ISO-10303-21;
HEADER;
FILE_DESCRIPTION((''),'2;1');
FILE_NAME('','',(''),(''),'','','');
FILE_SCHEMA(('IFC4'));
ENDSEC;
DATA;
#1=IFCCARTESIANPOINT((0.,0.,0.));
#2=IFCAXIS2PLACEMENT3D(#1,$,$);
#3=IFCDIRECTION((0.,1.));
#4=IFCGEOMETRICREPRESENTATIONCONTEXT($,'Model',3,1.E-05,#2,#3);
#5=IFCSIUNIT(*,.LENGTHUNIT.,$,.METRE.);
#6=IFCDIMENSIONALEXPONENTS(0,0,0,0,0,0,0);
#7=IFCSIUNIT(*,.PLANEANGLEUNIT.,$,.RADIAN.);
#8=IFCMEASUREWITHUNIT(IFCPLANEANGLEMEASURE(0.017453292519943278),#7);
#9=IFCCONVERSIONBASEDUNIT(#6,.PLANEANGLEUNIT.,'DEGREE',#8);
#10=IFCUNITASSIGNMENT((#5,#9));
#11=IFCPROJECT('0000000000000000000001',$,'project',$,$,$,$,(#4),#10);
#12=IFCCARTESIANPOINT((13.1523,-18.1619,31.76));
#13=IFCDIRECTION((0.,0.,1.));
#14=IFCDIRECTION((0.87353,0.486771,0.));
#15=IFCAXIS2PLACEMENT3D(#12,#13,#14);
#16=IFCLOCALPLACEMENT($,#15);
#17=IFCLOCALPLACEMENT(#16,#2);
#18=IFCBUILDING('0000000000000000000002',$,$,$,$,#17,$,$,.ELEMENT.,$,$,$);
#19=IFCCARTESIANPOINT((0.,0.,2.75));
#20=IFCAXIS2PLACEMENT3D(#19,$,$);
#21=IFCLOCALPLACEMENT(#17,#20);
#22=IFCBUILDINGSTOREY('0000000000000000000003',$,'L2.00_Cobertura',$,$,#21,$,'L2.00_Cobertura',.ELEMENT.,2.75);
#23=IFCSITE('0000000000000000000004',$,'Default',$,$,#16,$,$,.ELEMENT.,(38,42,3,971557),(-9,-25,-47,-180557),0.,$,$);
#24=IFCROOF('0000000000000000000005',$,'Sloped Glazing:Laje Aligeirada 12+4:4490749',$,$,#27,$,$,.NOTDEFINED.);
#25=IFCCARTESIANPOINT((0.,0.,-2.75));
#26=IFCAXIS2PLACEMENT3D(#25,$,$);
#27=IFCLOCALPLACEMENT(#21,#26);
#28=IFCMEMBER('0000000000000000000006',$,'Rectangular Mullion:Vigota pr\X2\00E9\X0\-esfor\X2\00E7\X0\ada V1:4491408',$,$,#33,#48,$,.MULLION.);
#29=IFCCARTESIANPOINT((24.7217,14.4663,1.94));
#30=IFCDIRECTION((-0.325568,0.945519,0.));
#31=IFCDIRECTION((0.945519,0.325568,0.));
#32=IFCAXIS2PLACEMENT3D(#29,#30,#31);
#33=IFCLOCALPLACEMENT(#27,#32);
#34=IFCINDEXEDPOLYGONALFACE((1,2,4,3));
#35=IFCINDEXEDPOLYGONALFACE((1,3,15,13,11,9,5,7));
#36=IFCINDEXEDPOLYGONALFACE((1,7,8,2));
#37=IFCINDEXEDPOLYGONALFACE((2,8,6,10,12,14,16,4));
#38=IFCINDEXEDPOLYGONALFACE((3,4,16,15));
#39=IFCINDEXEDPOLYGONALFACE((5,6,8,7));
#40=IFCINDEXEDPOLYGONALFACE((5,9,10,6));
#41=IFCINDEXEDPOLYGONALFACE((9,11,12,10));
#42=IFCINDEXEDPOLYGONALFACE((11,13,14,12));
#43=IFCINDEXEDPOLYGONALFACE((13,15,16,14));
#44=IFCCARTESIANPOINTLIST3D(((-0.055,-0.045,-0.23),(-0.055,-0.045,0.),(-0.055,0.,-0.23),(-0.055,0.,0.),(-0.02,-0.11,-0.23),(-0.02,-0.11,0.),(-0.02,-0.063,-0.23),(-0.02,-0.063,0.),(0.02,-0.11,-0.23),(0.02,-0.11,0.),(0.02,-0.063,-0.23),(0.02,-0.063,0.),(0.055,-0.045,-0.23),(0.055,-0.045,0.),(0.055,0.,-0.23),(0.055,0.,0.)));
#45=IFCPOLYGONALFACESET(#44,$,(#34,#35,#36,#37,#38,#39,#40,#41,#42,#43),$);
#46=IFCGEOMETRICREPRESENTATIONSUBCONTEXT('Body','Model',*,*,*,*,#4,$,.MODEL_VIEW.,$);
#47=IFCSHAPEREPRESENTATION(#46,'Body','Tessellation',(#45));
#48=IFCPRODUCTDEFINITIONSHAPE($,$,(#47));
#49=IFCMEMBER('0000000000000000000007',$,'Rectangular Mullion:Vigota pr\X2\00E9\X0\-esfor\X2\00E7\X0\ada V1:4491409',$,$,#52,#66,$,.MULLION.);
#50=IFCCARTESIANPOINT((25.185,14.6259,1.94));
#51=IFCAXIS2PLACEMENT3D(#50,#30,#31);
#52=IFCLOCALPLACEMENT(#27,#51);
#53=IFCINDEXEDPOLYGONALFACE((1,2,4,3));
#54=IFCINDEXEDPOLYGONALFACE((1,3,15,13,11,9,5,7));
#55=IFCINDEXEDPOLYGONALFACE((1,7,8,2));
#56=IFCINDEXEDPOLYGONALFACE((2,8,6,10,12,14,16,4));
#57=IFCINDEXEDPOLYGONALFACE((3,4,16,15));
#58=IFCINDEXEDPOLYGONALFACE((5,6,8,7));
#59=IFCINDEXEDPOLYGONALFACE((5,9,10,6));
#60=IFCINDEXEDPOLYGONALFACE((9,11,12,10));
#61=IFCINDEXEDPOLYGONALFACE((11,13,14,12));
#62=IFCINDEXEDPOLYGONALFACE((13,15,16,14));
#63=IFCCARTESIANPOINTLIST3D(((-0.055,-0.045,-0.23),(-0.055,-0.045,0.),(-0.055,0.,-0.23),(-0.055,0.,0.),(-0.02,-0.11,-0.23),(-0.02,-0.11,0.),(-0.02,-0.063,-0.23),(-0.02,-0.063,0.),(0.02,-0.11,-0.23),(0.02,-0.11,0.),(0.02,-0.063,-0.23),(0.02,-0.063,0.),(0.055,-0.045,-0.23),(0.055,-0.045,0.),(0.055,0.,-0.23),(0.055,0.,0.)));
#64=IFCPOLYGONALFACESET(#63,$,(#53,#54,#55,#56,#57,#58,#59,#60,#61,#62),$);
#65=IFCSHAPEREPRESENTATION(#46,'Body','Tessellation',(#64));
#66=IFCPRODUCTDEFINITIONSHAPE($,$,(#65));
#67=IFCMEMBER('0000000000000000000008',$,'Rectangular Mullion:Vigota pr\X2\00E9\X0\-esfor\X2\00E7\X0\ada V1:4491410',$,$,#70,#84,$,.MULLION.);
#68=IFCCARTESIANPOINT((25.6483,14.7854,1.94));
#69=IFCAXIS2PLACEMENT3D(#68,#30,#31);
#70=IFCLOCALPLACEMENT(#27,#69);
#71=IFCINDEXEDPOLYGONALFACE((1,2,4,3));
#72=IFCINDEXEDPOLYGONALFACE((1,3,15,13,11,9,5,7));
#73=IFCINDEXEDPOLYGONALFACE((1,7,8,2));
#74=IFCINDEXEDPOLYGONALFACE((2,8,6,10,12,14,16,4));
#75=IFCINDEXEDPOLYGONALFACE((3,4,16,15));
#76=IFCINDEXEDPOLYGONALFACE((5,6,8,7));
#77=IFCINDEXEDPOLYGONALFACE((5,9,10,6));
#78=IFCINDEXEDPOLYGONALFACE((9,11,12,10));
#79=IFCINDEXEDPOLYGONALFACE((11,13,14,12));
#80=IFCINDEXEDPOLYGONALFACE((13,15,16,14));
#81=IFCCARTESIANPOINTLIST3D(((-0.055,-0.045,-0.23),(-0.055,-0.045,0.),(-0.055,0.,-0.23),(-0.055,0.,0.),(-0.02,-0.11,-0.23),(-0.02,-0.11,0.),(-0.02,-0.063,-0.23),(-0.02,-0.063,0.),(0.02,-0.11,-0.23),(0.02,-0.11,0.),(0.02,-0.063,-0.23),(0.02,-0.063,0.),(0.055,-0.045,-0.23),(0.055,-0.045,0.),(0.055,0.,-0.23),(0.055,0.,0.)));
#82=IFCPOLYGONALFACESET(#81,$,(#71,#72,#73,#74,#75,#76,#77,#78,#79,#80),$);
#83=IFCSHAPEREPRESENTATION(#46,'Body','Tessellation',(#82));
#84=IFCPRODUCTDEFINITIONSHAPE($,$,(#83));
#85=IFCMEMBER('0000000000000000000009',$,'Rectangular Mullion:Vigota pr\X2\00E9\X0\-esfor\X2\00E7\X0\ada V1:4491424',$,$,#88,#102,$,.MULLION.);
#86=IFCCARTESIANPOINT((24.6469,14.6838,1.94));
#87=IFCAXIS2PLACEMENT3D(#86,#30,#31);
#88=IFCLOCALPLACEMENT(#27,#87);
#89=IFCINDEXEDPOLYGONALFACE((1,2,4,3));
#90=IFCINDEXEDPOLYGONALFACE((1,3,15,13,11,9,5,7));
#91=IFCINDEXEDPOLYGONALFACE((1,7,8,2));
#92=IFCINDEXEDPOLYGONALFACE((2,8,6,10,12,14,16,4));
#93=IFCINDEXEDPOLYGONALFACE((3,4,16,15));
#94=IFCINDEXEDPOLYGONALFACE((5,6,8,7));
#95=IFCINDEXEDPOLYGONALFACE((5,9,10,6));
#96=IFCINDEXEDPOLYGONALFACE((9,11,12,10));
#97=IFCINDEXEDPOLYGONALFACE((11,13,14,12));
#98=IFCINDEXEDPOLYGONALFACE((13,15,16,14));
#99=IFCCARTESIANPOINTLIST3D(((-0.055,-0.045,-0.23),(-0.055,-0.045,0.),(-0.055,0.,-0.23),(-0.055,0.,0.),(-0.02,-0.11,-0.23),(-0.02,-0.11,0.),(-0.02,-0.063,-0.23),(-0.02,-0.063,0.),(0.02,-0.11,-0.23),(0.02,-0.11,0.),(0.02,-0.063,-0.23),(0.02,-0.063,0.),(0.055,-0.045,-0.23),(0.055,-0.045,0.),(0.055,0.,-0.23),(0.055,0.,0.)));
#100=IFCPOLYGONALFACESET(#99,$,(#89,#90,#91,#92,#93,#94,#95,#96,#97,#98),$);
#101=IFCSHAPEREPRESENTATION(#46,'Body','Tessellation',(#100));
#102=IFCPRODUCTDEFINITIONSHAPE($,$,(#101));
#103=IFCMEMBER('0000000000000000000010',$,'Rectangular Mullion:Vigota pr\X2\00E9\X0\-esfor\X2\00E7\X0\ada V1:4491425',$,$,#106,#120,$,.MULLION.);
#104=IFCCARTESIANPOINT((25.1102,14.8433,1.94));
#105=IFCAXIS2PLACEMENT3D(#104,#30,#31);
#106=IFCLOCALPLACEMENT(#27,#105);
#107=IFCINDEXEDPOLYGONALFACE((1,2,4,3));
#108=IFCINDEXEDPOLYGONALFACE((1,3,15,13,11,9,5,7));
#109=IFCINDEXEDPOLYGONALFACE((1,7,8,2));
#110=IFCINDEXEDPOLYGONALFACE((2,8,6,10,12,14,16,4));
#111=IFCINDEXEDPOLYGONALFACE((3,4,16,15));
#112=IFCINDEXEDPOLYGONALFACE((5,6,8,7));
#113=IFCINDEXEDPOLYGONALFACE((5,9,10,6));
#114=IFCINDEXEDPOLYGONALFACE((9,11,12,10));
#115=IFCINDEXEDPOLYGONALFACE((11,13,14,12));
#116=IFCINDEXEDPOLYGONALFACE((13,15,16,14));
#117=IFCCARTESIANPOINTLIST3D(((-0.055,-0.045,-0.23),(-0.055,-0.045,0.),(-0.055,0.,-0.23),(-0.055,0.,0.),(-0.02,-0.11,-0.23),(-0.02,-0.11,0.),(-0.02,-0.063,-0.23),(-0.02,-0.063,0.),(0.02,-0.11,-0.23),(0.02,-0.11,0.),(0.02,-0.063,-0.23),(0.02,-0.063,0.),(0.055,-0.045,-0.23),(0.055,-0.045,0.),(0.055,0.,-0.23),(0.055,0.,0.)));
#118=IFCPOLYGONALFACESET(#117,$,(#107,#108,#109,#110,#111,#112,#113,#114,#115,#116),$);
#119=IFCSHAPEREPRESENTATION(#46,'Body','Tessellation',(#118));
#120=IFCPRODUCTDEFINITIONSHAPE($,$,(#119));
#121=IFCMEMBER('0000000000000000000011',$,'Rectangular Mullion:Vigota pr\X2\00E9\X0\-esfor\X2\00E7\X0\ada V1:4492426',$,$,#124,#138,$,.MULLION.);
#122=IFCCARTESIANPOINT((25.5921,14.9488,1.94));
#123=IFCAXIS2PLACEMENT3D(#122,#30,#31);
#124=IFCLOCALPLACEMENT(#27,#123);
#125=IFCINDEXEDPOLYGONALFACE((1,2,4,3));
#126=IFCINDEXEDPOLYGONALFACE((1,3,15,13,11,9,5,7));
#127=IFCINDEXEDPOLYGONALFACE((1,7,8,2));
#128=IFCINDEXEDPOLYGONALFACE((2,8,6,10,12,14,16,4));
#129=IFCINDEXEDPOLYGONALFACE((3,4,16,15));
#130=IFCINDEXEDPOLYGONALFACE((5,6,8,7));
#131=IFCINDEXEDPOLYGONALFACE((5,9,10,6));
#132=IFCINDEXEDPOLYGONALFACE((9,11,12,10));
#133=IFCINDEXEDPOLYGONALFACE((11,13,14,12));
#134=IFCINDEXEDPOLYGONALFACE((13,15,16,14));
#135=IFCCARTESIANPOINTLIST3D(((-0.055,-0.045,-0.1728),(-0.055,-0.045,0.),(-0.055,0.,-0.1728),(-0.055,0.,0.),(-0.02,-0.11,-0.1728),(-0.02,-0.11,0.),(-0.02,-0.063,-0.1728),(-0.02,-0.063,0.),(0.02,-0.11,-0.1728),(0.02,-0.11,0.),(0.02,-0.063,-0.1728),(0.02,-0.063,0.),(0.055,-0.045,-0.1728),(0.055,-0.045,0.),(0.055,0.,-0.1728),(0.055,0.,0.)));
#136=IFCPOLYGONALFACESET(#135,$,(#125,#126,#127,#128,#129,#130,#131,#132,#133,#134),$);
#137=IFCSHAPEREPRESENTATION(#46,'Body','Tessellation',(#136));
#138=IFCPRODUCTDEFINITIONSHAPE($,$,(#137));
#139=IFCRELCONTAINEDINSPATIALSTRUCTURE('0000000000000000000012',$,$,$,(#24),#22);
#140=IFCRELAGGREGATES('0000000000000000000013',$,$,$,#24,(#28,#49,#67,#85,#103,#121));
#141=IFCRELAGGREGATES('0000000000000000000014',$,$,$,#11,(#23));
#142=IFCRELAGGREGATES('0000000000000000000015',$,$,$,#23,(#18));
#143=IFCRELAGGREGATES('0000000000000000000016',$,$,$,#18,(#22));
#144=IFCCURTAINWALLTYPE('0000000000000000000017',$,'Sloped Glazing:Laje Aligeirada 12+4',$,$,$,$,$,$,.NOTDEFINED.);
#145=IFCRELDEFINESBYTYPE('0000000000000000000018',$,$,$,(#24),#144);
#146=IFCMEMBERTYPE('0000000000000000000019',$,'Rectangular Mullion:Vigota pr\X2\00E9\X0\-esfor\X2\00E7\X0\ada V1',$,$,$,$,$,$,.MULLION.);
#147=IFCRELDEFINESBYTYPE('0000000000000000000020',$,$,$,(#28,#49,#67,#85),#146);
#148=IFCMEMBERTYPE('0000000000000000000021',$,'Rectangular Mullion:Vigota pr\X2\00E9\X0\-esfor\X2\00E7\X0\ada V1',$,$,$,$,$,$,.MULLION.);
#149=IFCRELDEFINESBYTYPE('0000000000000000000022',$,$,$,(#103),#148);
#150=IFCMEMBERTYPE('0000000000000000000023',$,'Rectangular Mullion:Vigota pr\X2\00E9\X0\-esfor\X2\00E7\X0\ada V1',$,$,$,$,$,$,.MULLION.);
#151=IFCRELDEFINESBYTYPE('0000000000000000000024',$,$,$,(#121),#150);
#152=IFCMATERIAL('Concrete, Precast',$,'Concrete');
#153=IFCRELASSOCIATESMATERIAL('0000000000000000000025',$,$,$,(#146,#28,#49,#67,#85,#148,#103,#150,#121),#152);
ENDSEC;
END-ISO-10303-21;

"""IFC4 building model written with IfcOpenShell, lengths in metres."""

from ifc_helpers import new_model, entity, si_unit, converted_unit, direction, frame, origin, place, context, subcontext, project, spatial, indexed_curve, outline, extrude, source, transform, mapped, material, type_object, type_shapes, element, aggregate, save


model = new_model("IFC4")

# Units and contexts
model_context = context("Model", 3, precision=1e-05, world=origin(), true_north=direction((0.0, 1.0)))
body_context = subcontext(model_context, "Body", "Model", "MODEL_VIEW")
ifc_project = project(units=[si_unit("LENGTHUNIT", "METRE"), converted_unit("PLANEANGLEUNIT", "DEGREE", entity("IfcPlaneAngleMeasure", 0.017453292519943278), si_unit("PLANEANGLEUNIT", "RADIAN"), dimensions=[0, 0, 0, 0, 0, 0, 0])], contexts=[model_context])

# Site, building, storey
site_placement = place(None, frame((13.1523, -18.1619, 31.76), z_axis=(0.0, 0.0, 1.0), x_axis=(0.87353, 0.486771, 0.0)))
site = spatial("IfcSite", under=ifc_project, at=site_placement, Name="Default", CompositionType="ELEMENT", RefLatitude=(38, 42, 3, 971557), RefLongitude=(-9, -25, -47, -180557), RefElevation=0.0)
building_placement = place(site_placement, origin())
building = spatial("IfcBuilding", under=site, at=building_placement, CompositionType="ELEMENT")
storey_placement = place(building_placement, frame((0.0, 0.0, 2.75)))
storey = spatial("IfcBuildingStorey", under=building, at=storey_placement, Name="L2.00_Cobertura", LongName="L2.00_Cobertura", CompositionType="ELEMENT", Elevation=2.75)

# Roof, members
curtain_wall_type = type_object("IfcCurtainWallType", Name="Sloped Glazing:Laje Aligeirada 12+4", PredefinedType="NOTDEFINED")
roof_placement = place(storey_placement, frame((0.0, 0.0, -2.75)))
roof = element("IfcRoof", 1, at=roof_placement, inside=storey, type_object=curtain_wall_type, Name="Sloped Glazing:Laje Aligeirada 12+4:4490749", PredefinedType="NOTDEFINED")
ifc_material_1 = material(Name="Concrete, Precast", Category="Concrete")
member_type_1 = type_object("IfcMemberType", Name="Rectangular Mullion:Vigota pré-esforçada V1", PredefinedType="MULLION", material=ifc_material_1)
shared_shape_1 = source(origin(), body_context, "Body", "SweptSolid", [
    extrude(outline(indexed_curve([(-0.055, -0.0545), (0.055, -0.0545), (0.055, -0.0095), (0.02, 0.0085), (0.02, 0.0555), (-0.02, 0.0555), (-0.02, 0.0085), (-0.055, -0.0095), (-0.055, -0.0545)], self_intersect=False)), frame((0.0, -0.0545, -0.23), z_axis=(0.0, 0.0, 1.0), x_axis=(-1.0, 0.0, 0.0)), (0.0, 0.0, 1.0), 0.23),
])
type_shapes(member_type_1, [shared_shape_1])
member_1_placement = place(roof_placement, frame((24.7217, 14.4663, 1.94), z_axis=(-0.325568, 0.945519, 0.0), x_axis=(0.945519, 0.325568, 0.0)))
member_1 = element("IfcMember", 2, at=member_1_placement, type_object=member_type_1, material=ifc_material_1, Name="Rectangular Mullion:Vigota pré-esforçada V1:4491408", PredefinedType="MULLION", context=body_context, shape_type="MappedRepresentation", body=[
    mapped(shared_shape_1, transform((0.0, 0.0, 0.0), scale=1.0)),
])
member_2_placement = place(roof_placement, frame((25.185, 14.6259, 1.94), z_axis=(-0.325568, 0.945519, 0.0), x_axis=(0.945519, 0.325568, 0.0)))
member_2 = element("IfcMember", 3, at=member_2_placement, type_object=member_type_1, material=ifc_material_1, Name="Rectangular Mullion:Vigota pré-esforçada V1:4491409", PredefinedType="MULLION", context=body_context, shape_type="MappedRepresentation", body=[
    mapped(shared_shape_1, transform((0.0, 0.0, 0.0), scale=1.0)),
])
member_3_placement = place(roof_placement, frame((25.6483, 14.7854, 1.94), z_axis=(-0.325568, 0.945519, 0.0), x_axis=(0.945519, 0.325568, 0.0)))
member_3 = element("IfcMember", 4, at=member_3_placement, type_object=member_type_1, material=ifc_material_1, Name="Rectangular Mullion:Vigota pré-esforçada V1:4491410", PredefinedType="MULLION", context=body_context, shape_type="MappedRepresentation", body=[
    mapped(shared_shape_1, transform((0.0, 0.0, 0.0), scale=1.0)),
])
member_4_placement = place(roof_placement, frame((24.6469, 14.6838, 1.94), z_axis=(-0.325568, 0.945519, 0.0), x_axis=(0.945519, 0.325568, 0.0)))
member_4 = element("IfcMember", 5, at=member_4_placement, type_object=member_type_1, material=ifc_material_1, Name="Rectangular Mullion:Vigota pré-esforçada V1:4491424", PredefinedType="MULLION", context=body_context, shape_type="MappedRepresentation", body=[
    mapped(shared_shape_1, transform((0.0, 0.0, 0.0), scale=1.0)),
])
member_type_2 = type_object("IfcMemberType", Name="Rectangular Mullion:Vigota pré-esforçada V1", PredefinedType="MULLION", material=ifc_material_1)
shared_shape_2 = source(origin(), body_context, "Body", "SweptSolid", [
    extrude(outline(indexed_curve([(-0.055, -0.0545), (0.055, -0.0545), (0.055, -0.0095), (0.02, 0.0085), (0.02, 0.0555), (-0.02, 0.0555), (-0.02, 0.0085), (-0.055, -0.0095), (-0.055, -0.0545)], self_intersect=False)), frame((0.0, -0.0545, -0.23), z_axis=(0.0, 0.0, 1.0), x_axis=(-1.0, 0.0, 0.0)), (0.0, 0.0, 1.0), 0.23),
])
type_shapes(member_type_2, [shared_shape_2])
member_5_placement = place(roof_placement, frame((25.1102, 14.8433, 1.94), z_axis=(-0.325568, 0.945519, 0.0), x_axis=(0.945519, 0.325568, 0.0)))
member_5 = element("IfcMember", 6, at=member_5_placement, type_object=member_type_2, material=ifc_material_1, Name="Rectangular Mullion:Vigota pré-esforçada V1:4491425", PredefinedType="MULLION", context=body_context, shape_type="MappedRepresentation", body=[
    mapped(shared_shape_2, transform((0.0, 0.0, 0.0), scale=1.0)),
])
member_type_3 = type_object("IfcMemberType", Name="Rectangular Mullion:Vigota pré-esforçada V1", PredefinedType="MULLION", material=ifc_material_1)
shared_shape_3 = source(origin(), body_context, "Body", "SweptSolid", [
    extrude(outline(indexed_curve([(-0.055, -0.0545), (0.055, -0.0545), (0.055, -0.0095), (0.02, 0.0085), (0.02, 0.0555), (-0.02, 0.0555), (-0.02, 0.0085), (-0.055, -0.0095), (-0.055, -0.0545)], self_intersect=False)), frame((0.0, -0.0545, -0.1728), z_axis=(0.0, 0.0, 1.0), x_axis=(-1.0, 0.0, 0.0)), (0.0, 0.0, 1.0), 0.1728),
])
type_shapes(member_type_3, [shared_shape_3])
member_6_placement = place(roof_placement, frame((25.5921, 14.9488, 1.94), z_axis=(-0.325568, 0.945519, 0.0), x_axis=(0.945519, 0.325568, 0.0)))
member_6 = element("IfcMember", 7, at=member_6_placement, type_object=member_type_3, material=ifc_material_1, Name="Rectangular Mullion:Vigota pré-esforçada V1:4492426", PredefinedType="MULLION", context=body_context, shape_type="MappedRepresentation", body=[
    mapped(shared_shape_3, transform((0.0, 0.0, 0.0), scale=1.0)),
])
aggregate(roof, [member_1, member_2, member_3, member_4, member_5, member_6])

save(model, "model.ifc")
